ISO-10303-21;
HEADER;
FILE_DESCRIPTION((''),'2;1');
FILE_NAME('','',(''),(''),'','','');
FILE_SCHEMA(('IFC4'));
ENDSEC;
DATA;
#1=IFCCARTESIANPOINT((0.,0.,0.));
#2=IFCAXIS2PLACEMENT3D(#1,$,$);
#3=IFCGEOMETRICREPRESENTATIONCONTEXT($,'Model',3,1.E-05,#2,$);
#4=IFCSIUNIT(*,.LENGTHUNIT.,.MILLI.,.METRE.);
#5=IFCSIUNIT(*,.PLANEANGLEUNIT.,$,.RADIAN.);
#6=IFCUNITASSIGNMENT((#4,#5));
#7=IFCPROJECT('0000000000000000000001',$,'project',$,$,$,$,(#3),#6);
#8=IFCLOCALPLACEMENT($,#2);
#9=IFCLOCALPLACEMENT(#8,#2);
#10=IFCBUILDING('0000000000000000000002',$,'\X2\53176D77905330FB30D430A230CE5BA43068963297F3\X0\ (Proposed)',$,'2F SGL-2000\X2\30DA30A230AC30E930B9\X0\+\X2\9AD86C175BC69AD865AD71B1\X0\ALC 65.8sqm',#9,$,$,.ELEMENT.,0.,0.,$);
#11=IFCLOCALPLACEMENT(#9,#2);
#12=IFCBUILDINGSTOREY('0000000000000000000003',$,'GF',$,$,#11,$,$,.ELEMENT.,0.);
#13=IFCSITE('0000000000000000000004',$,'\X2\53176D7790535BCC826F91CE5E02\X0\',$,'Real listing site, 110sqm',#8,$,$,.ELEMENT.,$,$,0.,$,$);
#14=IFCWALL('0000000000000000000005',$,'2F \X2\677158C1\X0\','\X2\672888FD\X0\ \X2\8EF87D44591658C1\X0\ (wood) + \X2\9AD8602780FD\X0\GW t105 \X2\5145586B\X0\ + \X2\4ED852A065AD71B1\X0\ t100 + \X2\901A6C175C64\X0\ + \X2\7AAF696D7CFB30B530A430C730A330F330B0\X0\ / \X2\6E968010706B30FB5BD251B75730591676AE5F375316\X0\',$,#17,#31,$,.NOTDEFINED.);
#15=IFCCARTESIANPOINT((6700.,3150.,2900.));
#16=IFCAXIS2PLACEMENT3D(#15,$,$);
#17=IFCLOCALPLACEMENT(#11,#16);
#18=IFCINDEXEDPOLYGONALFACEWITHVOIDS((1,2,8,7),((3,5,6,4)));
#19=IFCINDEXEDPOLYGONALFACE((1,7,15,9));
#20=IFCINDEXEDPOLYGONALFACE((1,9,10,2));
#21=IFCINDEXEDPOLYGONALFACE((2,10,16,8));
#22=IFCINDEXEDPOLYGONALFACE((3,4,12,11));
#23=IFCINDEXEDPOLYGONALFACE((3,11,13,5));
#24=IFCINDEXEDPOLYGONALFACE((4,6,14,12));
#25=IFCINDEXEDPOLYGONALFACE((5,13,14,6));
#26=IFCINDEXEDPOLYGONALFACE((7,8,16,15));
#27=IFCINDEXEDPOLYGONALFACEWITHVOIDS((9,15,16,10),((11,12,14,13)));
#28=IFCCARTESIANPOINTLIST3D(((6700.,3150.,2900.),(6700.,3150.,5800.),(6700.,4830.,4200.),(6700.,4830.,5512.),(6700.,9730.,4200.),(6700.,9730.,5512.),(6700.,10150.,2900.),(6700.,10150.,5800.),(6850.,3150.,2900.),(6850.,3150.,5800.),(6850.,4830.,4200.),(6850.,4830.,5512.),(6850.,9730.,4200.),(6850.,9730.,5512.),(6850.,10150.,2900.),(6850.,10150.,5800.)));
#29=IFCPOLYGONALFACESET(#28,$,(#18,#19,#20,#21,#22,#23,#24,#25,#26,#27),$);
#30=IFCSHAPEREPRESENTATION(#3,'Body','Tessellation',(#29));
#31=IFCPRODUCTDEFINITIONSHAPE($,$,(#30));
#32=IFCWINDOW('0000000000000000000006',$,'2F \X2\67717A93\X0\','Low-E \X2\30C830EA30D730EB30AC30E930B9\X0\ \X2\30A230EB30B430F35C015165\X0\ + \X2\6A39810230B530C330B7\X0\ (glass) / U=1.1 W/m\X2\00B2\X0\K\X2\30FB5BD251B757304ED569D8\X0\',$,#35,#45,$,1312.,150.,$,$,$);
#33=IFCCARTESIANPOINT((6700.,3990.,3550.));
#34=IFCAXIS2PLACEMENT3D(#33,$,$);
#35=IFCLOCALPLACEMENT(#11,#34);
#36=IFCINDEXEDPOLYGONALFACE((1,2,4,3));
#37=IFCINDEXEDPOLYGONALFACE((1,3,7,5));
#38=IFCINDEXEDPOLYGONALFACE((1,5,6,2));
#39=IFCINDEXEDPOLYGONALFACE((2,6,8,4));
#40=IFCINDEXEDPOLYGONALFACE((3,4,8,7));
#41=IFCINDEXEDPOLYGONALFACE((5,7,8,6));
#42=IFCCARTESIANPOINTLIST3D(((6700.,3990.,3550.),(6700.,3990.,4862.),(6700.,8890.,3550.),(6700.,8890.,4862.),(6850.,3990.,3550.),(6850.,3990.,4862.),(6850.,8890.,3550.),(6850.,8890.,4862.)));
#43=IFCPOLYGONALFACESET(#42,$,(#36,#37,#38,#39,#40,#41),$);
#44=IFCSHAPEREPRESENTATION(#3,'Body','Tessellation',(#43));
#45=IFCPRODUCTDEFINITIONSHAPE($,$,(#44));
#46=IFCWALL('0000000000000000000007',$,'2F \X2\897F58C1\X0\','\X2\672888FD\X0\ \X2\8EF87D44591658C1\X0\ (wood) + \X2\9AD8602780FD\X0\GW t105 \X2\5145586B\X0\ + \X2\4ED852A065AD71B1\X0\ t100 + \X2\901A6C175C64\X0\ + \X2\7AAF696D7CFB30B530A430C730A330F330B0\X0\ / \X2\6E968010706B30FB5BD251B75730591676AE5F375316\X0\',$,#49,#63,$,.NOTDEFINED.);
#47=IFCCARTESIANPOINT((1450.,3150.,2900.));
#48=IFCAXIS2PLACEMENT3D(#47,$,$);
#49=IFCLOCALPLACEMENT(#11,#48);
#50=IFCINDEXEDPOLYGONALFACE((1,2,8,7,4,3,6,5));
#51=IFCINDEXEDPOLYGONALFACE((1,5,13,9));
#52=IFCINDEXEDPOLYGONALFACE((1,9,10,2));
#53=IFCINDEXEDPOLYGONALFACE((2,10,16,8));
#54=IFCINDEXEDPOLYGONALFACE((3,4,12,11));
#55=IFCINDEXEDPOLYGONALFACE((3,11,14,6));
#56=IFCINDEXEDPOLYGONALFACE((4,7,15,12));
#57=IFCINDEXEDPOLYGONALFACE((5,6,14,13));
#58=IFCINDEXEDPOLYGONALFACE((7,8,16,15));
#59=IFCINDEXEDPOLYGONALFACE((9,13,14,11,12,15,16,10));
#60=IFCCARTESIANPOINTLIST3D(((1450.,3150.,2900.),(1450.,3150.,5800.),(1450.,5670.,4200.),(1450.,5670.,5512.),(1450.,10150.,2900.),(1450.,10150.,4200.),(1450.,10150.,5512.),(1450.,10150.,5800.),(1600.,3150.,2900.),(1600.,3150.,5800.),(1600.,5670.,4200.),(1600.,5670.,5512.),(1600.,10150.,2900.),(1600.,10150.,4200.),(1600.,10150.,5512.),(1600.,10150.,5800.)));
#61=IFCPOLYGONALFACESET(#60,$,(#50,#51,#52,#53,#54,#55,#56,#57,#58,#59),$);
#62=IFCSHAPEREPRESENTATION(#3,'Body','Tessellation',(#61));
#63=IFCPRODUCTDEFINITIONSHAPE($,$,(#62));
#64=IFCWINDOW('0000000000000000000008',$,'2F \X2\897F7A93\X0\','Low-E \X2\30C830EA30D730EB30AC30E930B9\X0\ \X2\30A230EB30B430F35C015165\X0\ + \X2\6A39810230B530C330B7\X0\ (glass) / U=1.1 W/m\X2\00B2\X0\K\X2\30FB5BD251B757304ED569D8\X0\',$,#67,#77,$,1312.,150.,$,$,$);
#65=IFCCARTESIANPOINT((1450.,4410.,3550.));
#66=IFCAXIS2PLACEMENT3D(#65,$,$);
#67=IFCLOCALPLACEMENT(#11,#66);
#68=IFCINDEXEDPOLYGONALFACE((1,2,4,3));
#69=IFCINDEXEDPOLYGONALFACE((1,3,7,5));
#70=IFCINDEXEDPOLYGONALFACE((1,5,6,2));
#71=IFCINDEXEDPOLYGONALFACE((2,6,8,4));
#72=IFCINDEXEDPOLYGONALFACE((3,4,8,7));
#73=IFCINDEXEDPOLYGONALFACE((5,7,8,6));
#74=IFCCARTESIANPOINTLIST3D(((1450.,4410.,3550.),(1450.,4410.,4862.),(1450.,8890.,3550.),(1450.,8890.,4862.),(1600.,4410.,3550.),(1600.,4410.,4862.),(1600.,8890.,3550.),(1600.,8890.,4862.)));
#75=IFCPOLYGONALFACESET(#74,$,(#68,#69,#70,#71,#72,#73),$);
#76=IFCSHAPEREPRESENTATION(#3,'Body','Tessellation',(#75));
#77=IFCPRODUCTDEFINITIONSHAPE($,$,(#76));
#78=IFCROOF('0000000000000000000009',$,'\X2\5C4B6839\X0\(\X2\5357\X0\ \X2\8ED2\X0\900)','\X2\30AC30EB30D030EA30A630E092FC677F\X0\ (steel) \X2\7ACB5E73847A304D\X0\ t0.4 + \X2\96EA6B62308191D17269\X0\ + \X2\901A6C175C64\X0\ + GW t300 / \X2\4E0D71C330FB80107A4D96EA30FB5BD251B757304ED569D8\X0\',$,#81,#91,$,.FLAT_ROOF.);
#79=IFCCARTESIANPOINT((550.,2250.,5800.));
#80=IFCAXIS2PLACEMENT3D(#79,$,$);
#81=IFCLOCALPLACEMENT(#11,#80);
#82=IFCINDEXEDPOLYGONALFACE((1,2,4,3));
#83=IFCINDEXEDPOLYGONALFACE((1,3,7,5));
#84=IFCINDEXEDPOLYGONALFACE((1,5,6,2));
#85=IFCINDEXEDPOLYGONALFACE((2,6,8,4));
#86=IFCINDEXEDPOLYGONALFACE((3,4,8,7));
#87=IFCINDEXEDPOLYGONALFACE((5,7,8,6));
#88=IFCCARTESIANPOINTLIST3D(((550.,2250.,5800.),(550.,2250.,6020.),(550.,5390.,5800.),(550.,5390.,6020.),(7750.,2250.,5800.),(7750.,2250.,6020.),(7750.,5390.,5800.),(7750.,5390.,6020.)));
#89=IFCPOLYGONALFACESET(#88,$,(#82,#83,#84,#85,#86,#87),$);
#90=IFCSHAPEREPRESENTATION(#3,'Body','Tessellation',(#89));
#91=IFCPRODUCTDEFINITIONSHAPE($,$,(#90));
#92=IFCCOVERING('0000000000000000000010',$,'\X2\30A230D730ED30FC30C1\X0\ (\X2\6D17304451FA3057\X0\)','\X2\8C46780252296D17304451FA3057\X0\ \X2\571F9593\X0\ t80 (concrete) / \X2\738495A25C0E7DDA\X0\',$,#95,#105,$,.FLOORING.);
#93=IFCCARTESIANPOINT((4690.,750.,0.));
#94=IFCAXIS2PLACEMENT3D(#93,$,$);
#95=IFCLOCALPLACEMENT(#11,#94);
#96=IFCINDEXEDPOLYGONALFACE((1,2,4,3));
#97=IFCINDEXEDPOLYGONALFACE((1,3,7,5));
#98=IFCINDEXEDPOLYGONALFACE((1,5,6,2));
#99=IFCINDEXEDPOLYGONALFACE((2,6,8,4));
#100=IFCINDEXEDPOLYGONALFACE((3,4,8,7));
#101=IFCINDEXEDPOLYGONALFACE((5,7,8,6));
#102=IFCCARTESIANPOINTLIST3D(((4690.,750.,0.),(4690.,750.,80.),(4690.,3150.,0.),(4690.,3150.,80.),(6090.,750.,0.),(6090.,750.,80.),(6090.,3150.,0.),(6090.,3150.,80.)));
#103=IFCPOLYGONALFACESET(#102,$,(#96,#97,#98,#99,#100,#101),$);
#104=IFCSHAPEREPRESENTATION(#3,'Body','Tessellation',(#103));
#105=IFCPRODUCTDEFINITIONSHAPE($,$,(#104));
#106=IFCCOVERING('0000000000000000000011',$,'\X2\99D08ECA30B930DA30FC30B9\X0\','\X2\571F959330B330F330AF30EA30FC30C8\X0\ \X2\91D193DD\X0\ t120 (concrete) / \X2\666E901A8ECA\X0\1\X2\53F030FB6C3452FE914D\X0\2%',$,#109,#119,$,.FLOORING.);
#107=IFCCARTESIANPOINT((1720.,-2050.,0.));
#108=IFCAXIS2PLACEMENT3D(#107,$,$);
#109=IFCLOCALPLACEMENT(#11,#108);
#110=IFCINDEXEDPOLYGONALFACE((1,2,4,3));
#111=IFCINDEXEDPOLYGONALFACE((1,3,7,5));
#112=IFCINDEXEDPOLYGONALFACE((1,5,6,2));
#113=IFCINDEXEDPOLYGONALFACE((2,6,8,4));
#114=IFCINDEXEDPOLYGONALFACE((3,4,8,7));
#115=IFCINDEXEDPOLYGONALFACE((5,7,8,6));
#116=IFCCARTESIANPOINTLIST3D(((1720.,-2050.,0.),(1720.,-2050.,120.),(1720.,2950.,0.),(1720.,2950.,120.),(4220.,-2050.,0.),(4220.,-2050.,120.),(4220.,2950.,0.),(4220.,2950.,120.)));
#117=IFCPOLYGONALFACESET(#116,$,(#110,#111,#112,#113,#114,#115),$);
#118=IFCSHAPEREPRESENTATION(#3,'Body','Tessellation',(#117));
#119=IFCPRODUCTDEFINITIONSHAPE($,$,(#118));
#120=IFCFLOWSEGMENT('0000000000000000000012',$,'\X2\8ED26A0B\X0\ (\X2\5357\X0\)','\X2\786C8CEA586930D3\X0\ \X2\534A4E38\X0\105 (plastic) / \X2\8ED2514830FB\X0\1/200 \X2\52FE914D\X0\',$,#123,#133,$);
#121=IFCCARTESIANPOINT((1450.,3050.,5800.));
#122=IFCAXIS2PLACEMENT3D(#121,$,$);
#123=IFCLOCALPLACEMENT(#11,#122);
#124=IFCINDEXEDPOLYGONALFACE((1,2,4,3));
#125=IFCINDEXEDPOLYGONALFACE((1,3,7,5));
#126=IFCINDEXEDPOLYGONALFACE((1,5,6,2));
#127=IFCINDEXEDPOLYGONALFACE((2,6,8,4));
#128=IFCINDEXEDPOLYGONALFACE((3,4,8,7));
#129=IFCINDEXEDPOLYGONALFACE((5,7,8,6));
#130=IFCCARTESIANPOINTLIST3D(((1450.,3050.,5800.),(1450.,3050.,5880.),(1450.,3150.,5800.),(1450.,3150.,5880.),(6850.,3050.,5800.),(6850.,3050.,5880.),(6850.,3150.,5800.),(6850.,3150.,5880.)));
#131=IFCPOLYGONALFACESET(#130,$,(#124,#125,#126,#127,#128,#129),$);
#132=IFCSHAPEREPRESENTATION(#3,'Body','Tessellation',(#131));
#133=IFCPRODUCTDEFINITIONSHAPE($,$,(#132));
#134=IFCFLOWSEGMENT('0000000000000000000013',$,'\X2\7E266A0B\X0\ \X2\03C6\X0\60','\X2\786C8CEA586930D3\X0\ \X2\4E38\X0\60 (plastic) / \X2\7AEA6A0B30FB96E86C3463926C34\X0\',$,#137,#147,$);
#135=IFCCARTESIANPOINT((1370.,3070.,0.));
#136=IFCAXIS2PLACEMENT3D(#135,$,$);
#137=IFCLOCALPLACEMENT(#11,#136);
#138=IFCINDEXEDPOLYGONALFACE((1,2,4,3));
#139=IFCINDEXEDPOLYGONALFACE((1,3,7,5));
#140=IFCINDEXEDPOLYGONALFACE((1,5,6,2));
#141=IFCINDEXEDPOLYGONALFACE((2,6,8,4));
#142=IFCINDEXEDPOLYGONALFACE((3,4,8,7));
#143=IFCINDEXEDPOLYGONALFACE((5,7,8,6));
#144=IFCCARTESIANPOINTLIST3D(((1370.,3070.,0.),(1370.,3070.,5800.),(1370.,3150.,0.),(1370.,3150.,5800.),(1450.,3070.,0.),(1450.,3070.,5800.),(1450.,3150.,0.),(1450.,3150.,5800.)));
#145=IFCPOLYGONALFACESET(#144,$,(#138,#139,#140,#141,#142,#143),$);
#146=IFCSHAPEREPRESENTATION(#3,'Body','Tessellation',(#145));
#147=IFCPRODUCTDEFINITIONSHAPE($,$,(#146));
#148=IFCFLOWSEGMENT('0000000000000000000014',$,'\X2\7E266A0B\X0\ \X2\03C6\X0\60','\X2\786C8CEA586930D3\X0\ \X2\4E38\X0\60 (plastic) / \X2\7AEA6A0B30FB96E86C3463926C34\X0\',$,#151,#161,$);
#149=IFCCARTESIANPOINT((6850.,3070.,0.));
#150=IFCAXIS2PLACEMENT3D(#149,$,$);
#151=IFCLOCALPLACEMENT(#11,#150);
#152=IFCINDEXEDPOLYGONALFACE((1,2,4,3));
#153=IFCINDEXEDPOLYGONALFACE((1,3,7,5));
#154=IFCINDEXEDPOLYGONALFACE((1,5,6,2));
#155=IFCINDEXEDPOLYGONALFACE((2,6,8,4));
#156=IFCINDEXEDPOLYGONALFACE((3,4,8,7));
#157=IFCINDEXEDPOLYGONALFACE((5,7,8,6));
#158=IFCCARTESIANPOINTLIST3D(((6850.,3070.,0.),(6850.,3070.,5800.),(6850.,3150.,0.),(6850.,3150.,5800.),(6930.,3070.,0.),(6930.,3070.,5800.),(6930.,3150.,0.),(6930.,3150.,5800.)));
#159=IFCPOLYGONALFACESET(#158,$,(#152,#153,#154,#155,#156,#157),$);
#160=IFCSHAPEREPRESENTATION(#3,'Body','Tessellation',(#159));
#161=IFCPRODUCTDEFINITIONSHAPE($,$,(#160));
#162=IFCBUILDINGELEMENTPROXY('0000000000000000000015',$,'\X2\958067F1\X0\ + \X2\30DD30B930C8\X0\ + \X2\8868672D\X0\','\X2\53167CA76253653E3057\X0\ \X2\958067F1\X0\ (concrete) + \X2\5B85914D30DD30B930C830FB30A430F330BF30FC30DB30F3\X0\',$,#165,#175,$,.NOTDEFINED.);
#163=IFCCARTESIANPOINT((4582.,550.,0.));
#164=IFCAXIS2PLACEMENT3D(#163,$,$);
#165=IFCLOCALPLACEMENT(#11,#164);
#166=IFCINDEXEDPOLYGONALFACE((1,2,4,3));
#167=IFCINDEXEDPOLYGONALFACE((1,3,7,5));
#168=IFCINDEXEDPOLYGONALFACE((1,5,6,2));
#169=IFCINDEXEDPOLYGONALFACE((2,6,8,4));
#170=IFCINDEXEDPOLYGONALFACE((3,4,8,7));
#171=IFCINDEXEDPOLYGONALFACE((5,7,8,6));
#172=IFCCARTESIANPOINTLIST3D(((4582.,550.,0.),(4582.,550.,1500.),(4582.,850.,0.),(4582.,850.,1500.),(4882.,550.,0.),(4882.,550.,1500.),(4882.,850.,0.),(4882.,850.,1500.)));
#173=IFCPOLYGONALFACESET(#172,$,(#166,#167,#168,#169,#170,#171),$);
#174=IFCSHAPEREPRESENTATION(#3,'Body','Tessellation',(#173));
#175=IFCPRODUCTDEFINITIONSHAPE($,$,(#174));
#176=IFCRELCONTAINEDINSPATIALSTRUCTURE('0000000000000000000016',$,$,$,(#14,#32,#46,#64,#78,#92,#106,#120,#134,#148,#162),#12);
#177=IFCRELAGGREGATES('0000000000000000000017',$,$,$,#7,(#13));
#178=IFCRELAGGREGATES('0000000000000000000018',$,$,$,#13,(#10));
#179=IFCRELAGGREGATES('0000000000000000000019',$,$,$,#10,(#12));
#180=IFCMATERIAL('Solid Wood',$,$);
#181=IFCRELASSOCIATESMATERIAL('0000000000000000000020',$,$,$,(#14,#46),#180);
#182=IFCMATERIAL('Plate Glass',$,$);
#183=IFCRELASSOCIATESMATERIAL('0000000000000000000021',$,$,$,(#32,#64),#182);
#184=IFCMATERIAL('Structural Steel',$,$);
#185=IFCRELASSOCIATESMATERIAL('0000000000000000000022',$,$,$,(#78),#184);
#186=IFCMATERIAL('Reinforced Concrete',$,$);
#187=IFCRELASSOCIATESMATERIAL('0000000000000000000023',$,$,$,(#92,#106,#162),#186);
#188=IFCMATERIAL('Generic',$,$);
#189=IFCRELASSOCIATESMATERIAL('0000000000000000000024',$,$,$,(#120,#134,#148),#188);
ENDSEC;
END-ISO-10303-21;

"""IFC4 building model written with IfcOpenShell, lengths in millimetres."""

from ifc_helpers import new_model, si_unit, frame, frame_2d, origin, place, context, project, spatial, rectangle, extrude, material, element, fill, save


model = new_model("IFC4")

# Units and contexts
model_context = context("Model", 3, precision=1e-05, world=origin())
ifc_project = project(units=[si_unit("LENGTHUNIT", "METRE", prefix="MILLI"), si_unit("PLANEANGLEUNIT", "RADIAN")], contexts=[model_context])

# Site, building, storey
site_placement = place(None, origin())
site = spatial("IfcSite", under=ifc_project, at=site_placement, Name="北海道富良野市", ObjectType="Real listing site, 110sqm", CompositionType="ELEMENT", RefElevation=0.0)
building_placement = place(site_placement, origin())
building = spatial("IfcBuilding", under=site, at=building_placement, Name="北海道・ピアノ室と防音 (Proposed)", ObjectType="2F SGL-2000ペアガラス+高気密高断熱ALC 65.8sqm", CompositionType="ELEMENT", ElevationOfRefHeight=0.0, ElevationOfTerrain=0.0)
storey_placement = place(building_placement, origin())
storey = spatial("IfcBuildingStorey", under=building, at=storey_placement, Name="GF", CompositionType="ELEMENT", Elevation=0.0)

# Shared definitions
ifc_material_1 = material(Name="Solid Wood")

# Shared definitions
ifc_material_2 = material(Name="Reinforced Concrete")

# Shared definitions
ifc_material_3 = material(Name="Plate Glass")

# Walls, openings, windows
wall_1_placement = place(storey_placement, frame((6700.0, 3150.0, 2900.0)))
wall_1 = element("IfcWall", 1, at=wall_1_placement, inside=storey, material=ifc_material_1, Name="2F 東壁", Description="木製 軸組外壁 (wood) + 高性能GW t105 充填 + 付加断熱 t100 + 通気層 + 窯業系サイディング / 準耐火・寒冷地外皮強化", PredefinedType="NOTDEFINED", context=model_context, shape_type="SweptSolid", body=[
    extrude(rectangle(XDim=150.0, YDim=7000.0, at=frame_2d((75.0, 3500.0))), frame((6700.0, 3150.0, 2900.0)), (0.0, 0.0, 1.0), 2900.0),
])
opening_1_placement = place(storey_placement, frame((6700.0, 3990.0, 3550.0)))
opening_1 = element("IfcOpeningElement", 2, at=opening_1_placement, cuts=wall_1, PredefinedType="NOTDEFINED", context=model_context, shape_type="SweptSolid", body=[
    extrude(rectangle(XDim=150.0, YDim=4900.0, at=frame_2d((75.0, 2450.0))), frame((6700.0, 3990.0, 3550.0)), (0.0, 0.0, 1.0), 1312.0),
])
window_1_placement = place(storey_placement, frame((6700.0, 3990.0, 3550.0)))
window_1 = element("IfcWindow", 3, at=window_1_placement, inside=storey, material=ifc_material_3, Name="2F 東窓", Description="Low-E トリプルガラス アルゴン封入 + 樹脂サッシ (glass) / U=1.1 W/m²K・寒冷地仕様", OverallHeight=1312.0, OverallWidth=150.0, context=model_context, shape_type="SweptSolid", body=[
    extrude(rectangle(XDim=150.0, YDim=4900.0, at=frame_2d((75.0, 2450.0))), frame((6700.0, 3990.0, 3550.0)), (0.0, 0.0, 1.0), 1312.0),
])
fill(opening_1, window_1)
wall_2_placement = place(storey_placement, frame((1450.0, 3150.0, 2900.0)))
wall_2 = element("IfcWall", 4, at=wall_2_placement, inside=storey, material=ifc_material_1, Name="2F 西壁", Description="木製 軸組外壁 (wood) + 高性能GW t105 充填 + 付加断熱 t100 + 通気層 + 窯業系サイディング / 準耐火・寒冷地外皮強化", PredefinedType="NOTDEFINED", context=model_context, shape_type="SweptSolid", body=[
    extrude(rectangle(XDim=150.0, YDim=7000.0, at=frame_2d((75.0, 3500.0))), frame((1450.0, 3150.0, 2900.0)), (0.0, 0.0, 1.0), 2900.0),
])
opening_2_placement = place(storey_placement, frame((1450.0, 4410.0, 3550.0)))
opening_2 = element("IfcOpeningElement", 5, at=opening_2_placement, cuts=wall_2, PredefinedType="NOTDEFINED", context=model_context, shape_type="SweptSolid", body=[
    extrude(rectangle(XDim=150.0, YDim=4480.0, at=frame_2d((75.0, 2240.0))), frame((1450.0, 4410.0, 3550.0)), (0.0, 0.0, 1.0), 1312.0),
])
window_2_placement = place(storey_placement, frame((1450.0, 4410.0, 3550.0)))
window_2 = element("IfcWindow", 6, at=window_2_placement, inside=storey, material=ifc_material_3, Name="2F 西窓", Description="Low-E トリプルガラス アルゴン封入 + 樹脂サッシ (glass) / U=1.1 W/m²K・寒冷地仕様", OverallHeight=1312.0, OverallWidth=150.0, context=model_context, shape_type="SweptSolid", body=[
    extrude(rectangle(XDim=150.0, YDim=4480.0, at=frame_2d((75.0, 2240.0))), frame((1450.0, 4410.0, 3550.0)), (0.0, 0.0, 1.0), 1312.0),
])
fill(opening_2, window_2)

# Roof
ifc_material_4 = material(Name="Structural Steel")
for number, where, name in (
    (7, (550.0, 2250.0, 5800.0), "屋根(南 軒900)"),
):
    element("IfcRoof", number, at=place(storey_placement, frame(where)), inside=storey, material=ifc_material_4, Name=name, Description="ガルバリウム鋼板 (steel) 立平葺き t0.4 + 雪止め金物 + 通気層 + GW t300 / 不燃・耐積雪・寒冷地仕様", PredefinedType="FLAT_ROOF", context=model_context, shape_type="SweptSolid", body=[
        extrude(rectangle(XDim=7200.0, YDim=3140.0, at=frame_2d((3600.0, 1570.0))), frame((550.0, 2250.0, 5800.0)), (0.0, 0.0, 1.0), 220.0),
    ])

# Coverings
covering_1_placement = place(storey_placement, frame((4690.0, 750.0, 0.0)))
element("IfcCovering", 8, at=covering_1_placement, inside=storey, material=ifc_material_2, Name="アプローチ (洗い出し)", Description="豆砂利洗い出し 土間 t80 (concrete) / 玄関導線", PredefinedType="FLOORING", context=model_context, shape_type="SweptSolid", body=[
    extrude(rectangle(XDim=1400.0, YDim=2400.0, at=frame_2d((700.0, 1200.0))), frame((4690.0, 750.0, 0.0)), (0.0, 0.0, 1.0), 80.0),
])
covering_2_placement = place(storey_placement, frame((1720.0, -2050.0, 0.0)))
element("IfcCovering", 9, at=covering_2_placement, inside=storey, material=ifc_material_2, Name="駐車スペース", Description="土間コンクリート 金鏝 t120 (concrete) / 普通車1台・水勾配2%", PredefinedType="FLOORING", context=model_context, shape_type="SweptSolid", body=[
    extrude(rectangle(XDim=2500.0, YDim=5000.0, at=frame_2d((1250.0, 2500.0))), frame((1720.0, -2050.0, 0.0)), (0.0, 0.0, 1.0), 120.0),
])

# Flow segments
ifc_material_5 = material(Name="Generic")
flow_segment_1_placement = place(storey_placement, frame((1450.0, 3050.0, 5800.0)))
element("IfcFlowSegment", 10, at=flow_segment_1_placement, inside=storey, material=ifc_material_5, Name="軒樋 (南)", Description="硬質塩ビ 半丸105 (plastic) / 軒先・1/200 勾配", context=model_context, shape_type="SweptSolid", body=[
    extrude(rectangle(XDim=5400.0, YDim=100.0, at=frame_2d((2700.0, 50.0))), frame((1450.0, 3050.0, 5800.0)), (0.0, 0.0, 1.0), 80.0),
])
flow_segment_2_placement = place(storey_placement, frame((1370.0, 3070.0, 0.0)))
element("IfcFlowSegment", 11, at=flow_segment_2_placement, inside=storey, material=ifc_material_5, Name="縦樋 φ60", Description="硬質塩ビ 丸60 (plastic) / 竪樋・雨水排水", context=model_context, shape_type="SweptSolid", body=[
    extrude(rectangle(XDim=80.0, YDim=80.0, at=frame_2d((40.0, 40.0))), frame((1370.0, 3070.0, 0.0)), (0.0, 0.0, 1.0), 5800.0),
])
flow_segment_3_placement = place(storey_placement, frame((6850.0, 3070.0, 0.0)))
element("IfcFlowSegment", 12, at=flow_segment_3_placement, inside=storey, material=ifc_material_5, Name="縦樋 φ60", Description="硬質塩ビ 丸60 (plastic) / 竪樋・雨水排水", context=model_context, shape_type="SweptSolid", body=[
    extrude(rectangle(XDim=80.0, YDim=80.0, at=frame_2d((40.0, 40.0))), frame((6850.0, 3070.0, 0.0)), (0.0, 0.0, 1.0), 5800.0),
])

# Building element proxy
proxy_placement = place(storey_placement, frame((4582.0, 550.0, 0.0)))
element("IfcBuildingElementProxy", 13, at=proxy_placement, inside=storey, material=ifc_material_2, Name="門柱 + ポスト + 表札", Description="化粧打放し 門柱 (concrete) + 宅配ポスト・インターホン", PredefinedType="NOTDEFINED", context=model_context, shape_type="SweptSolid", body=[
    extrude(rectangle(XDim=300.0, YDim=300.0, at=frame_2d((150.0, 150.0))), frame((4582.0, 550.0, 0.0)), (0.0, 0.0, 1.0), 1500.0),
])

save(model, "model.ifc")
